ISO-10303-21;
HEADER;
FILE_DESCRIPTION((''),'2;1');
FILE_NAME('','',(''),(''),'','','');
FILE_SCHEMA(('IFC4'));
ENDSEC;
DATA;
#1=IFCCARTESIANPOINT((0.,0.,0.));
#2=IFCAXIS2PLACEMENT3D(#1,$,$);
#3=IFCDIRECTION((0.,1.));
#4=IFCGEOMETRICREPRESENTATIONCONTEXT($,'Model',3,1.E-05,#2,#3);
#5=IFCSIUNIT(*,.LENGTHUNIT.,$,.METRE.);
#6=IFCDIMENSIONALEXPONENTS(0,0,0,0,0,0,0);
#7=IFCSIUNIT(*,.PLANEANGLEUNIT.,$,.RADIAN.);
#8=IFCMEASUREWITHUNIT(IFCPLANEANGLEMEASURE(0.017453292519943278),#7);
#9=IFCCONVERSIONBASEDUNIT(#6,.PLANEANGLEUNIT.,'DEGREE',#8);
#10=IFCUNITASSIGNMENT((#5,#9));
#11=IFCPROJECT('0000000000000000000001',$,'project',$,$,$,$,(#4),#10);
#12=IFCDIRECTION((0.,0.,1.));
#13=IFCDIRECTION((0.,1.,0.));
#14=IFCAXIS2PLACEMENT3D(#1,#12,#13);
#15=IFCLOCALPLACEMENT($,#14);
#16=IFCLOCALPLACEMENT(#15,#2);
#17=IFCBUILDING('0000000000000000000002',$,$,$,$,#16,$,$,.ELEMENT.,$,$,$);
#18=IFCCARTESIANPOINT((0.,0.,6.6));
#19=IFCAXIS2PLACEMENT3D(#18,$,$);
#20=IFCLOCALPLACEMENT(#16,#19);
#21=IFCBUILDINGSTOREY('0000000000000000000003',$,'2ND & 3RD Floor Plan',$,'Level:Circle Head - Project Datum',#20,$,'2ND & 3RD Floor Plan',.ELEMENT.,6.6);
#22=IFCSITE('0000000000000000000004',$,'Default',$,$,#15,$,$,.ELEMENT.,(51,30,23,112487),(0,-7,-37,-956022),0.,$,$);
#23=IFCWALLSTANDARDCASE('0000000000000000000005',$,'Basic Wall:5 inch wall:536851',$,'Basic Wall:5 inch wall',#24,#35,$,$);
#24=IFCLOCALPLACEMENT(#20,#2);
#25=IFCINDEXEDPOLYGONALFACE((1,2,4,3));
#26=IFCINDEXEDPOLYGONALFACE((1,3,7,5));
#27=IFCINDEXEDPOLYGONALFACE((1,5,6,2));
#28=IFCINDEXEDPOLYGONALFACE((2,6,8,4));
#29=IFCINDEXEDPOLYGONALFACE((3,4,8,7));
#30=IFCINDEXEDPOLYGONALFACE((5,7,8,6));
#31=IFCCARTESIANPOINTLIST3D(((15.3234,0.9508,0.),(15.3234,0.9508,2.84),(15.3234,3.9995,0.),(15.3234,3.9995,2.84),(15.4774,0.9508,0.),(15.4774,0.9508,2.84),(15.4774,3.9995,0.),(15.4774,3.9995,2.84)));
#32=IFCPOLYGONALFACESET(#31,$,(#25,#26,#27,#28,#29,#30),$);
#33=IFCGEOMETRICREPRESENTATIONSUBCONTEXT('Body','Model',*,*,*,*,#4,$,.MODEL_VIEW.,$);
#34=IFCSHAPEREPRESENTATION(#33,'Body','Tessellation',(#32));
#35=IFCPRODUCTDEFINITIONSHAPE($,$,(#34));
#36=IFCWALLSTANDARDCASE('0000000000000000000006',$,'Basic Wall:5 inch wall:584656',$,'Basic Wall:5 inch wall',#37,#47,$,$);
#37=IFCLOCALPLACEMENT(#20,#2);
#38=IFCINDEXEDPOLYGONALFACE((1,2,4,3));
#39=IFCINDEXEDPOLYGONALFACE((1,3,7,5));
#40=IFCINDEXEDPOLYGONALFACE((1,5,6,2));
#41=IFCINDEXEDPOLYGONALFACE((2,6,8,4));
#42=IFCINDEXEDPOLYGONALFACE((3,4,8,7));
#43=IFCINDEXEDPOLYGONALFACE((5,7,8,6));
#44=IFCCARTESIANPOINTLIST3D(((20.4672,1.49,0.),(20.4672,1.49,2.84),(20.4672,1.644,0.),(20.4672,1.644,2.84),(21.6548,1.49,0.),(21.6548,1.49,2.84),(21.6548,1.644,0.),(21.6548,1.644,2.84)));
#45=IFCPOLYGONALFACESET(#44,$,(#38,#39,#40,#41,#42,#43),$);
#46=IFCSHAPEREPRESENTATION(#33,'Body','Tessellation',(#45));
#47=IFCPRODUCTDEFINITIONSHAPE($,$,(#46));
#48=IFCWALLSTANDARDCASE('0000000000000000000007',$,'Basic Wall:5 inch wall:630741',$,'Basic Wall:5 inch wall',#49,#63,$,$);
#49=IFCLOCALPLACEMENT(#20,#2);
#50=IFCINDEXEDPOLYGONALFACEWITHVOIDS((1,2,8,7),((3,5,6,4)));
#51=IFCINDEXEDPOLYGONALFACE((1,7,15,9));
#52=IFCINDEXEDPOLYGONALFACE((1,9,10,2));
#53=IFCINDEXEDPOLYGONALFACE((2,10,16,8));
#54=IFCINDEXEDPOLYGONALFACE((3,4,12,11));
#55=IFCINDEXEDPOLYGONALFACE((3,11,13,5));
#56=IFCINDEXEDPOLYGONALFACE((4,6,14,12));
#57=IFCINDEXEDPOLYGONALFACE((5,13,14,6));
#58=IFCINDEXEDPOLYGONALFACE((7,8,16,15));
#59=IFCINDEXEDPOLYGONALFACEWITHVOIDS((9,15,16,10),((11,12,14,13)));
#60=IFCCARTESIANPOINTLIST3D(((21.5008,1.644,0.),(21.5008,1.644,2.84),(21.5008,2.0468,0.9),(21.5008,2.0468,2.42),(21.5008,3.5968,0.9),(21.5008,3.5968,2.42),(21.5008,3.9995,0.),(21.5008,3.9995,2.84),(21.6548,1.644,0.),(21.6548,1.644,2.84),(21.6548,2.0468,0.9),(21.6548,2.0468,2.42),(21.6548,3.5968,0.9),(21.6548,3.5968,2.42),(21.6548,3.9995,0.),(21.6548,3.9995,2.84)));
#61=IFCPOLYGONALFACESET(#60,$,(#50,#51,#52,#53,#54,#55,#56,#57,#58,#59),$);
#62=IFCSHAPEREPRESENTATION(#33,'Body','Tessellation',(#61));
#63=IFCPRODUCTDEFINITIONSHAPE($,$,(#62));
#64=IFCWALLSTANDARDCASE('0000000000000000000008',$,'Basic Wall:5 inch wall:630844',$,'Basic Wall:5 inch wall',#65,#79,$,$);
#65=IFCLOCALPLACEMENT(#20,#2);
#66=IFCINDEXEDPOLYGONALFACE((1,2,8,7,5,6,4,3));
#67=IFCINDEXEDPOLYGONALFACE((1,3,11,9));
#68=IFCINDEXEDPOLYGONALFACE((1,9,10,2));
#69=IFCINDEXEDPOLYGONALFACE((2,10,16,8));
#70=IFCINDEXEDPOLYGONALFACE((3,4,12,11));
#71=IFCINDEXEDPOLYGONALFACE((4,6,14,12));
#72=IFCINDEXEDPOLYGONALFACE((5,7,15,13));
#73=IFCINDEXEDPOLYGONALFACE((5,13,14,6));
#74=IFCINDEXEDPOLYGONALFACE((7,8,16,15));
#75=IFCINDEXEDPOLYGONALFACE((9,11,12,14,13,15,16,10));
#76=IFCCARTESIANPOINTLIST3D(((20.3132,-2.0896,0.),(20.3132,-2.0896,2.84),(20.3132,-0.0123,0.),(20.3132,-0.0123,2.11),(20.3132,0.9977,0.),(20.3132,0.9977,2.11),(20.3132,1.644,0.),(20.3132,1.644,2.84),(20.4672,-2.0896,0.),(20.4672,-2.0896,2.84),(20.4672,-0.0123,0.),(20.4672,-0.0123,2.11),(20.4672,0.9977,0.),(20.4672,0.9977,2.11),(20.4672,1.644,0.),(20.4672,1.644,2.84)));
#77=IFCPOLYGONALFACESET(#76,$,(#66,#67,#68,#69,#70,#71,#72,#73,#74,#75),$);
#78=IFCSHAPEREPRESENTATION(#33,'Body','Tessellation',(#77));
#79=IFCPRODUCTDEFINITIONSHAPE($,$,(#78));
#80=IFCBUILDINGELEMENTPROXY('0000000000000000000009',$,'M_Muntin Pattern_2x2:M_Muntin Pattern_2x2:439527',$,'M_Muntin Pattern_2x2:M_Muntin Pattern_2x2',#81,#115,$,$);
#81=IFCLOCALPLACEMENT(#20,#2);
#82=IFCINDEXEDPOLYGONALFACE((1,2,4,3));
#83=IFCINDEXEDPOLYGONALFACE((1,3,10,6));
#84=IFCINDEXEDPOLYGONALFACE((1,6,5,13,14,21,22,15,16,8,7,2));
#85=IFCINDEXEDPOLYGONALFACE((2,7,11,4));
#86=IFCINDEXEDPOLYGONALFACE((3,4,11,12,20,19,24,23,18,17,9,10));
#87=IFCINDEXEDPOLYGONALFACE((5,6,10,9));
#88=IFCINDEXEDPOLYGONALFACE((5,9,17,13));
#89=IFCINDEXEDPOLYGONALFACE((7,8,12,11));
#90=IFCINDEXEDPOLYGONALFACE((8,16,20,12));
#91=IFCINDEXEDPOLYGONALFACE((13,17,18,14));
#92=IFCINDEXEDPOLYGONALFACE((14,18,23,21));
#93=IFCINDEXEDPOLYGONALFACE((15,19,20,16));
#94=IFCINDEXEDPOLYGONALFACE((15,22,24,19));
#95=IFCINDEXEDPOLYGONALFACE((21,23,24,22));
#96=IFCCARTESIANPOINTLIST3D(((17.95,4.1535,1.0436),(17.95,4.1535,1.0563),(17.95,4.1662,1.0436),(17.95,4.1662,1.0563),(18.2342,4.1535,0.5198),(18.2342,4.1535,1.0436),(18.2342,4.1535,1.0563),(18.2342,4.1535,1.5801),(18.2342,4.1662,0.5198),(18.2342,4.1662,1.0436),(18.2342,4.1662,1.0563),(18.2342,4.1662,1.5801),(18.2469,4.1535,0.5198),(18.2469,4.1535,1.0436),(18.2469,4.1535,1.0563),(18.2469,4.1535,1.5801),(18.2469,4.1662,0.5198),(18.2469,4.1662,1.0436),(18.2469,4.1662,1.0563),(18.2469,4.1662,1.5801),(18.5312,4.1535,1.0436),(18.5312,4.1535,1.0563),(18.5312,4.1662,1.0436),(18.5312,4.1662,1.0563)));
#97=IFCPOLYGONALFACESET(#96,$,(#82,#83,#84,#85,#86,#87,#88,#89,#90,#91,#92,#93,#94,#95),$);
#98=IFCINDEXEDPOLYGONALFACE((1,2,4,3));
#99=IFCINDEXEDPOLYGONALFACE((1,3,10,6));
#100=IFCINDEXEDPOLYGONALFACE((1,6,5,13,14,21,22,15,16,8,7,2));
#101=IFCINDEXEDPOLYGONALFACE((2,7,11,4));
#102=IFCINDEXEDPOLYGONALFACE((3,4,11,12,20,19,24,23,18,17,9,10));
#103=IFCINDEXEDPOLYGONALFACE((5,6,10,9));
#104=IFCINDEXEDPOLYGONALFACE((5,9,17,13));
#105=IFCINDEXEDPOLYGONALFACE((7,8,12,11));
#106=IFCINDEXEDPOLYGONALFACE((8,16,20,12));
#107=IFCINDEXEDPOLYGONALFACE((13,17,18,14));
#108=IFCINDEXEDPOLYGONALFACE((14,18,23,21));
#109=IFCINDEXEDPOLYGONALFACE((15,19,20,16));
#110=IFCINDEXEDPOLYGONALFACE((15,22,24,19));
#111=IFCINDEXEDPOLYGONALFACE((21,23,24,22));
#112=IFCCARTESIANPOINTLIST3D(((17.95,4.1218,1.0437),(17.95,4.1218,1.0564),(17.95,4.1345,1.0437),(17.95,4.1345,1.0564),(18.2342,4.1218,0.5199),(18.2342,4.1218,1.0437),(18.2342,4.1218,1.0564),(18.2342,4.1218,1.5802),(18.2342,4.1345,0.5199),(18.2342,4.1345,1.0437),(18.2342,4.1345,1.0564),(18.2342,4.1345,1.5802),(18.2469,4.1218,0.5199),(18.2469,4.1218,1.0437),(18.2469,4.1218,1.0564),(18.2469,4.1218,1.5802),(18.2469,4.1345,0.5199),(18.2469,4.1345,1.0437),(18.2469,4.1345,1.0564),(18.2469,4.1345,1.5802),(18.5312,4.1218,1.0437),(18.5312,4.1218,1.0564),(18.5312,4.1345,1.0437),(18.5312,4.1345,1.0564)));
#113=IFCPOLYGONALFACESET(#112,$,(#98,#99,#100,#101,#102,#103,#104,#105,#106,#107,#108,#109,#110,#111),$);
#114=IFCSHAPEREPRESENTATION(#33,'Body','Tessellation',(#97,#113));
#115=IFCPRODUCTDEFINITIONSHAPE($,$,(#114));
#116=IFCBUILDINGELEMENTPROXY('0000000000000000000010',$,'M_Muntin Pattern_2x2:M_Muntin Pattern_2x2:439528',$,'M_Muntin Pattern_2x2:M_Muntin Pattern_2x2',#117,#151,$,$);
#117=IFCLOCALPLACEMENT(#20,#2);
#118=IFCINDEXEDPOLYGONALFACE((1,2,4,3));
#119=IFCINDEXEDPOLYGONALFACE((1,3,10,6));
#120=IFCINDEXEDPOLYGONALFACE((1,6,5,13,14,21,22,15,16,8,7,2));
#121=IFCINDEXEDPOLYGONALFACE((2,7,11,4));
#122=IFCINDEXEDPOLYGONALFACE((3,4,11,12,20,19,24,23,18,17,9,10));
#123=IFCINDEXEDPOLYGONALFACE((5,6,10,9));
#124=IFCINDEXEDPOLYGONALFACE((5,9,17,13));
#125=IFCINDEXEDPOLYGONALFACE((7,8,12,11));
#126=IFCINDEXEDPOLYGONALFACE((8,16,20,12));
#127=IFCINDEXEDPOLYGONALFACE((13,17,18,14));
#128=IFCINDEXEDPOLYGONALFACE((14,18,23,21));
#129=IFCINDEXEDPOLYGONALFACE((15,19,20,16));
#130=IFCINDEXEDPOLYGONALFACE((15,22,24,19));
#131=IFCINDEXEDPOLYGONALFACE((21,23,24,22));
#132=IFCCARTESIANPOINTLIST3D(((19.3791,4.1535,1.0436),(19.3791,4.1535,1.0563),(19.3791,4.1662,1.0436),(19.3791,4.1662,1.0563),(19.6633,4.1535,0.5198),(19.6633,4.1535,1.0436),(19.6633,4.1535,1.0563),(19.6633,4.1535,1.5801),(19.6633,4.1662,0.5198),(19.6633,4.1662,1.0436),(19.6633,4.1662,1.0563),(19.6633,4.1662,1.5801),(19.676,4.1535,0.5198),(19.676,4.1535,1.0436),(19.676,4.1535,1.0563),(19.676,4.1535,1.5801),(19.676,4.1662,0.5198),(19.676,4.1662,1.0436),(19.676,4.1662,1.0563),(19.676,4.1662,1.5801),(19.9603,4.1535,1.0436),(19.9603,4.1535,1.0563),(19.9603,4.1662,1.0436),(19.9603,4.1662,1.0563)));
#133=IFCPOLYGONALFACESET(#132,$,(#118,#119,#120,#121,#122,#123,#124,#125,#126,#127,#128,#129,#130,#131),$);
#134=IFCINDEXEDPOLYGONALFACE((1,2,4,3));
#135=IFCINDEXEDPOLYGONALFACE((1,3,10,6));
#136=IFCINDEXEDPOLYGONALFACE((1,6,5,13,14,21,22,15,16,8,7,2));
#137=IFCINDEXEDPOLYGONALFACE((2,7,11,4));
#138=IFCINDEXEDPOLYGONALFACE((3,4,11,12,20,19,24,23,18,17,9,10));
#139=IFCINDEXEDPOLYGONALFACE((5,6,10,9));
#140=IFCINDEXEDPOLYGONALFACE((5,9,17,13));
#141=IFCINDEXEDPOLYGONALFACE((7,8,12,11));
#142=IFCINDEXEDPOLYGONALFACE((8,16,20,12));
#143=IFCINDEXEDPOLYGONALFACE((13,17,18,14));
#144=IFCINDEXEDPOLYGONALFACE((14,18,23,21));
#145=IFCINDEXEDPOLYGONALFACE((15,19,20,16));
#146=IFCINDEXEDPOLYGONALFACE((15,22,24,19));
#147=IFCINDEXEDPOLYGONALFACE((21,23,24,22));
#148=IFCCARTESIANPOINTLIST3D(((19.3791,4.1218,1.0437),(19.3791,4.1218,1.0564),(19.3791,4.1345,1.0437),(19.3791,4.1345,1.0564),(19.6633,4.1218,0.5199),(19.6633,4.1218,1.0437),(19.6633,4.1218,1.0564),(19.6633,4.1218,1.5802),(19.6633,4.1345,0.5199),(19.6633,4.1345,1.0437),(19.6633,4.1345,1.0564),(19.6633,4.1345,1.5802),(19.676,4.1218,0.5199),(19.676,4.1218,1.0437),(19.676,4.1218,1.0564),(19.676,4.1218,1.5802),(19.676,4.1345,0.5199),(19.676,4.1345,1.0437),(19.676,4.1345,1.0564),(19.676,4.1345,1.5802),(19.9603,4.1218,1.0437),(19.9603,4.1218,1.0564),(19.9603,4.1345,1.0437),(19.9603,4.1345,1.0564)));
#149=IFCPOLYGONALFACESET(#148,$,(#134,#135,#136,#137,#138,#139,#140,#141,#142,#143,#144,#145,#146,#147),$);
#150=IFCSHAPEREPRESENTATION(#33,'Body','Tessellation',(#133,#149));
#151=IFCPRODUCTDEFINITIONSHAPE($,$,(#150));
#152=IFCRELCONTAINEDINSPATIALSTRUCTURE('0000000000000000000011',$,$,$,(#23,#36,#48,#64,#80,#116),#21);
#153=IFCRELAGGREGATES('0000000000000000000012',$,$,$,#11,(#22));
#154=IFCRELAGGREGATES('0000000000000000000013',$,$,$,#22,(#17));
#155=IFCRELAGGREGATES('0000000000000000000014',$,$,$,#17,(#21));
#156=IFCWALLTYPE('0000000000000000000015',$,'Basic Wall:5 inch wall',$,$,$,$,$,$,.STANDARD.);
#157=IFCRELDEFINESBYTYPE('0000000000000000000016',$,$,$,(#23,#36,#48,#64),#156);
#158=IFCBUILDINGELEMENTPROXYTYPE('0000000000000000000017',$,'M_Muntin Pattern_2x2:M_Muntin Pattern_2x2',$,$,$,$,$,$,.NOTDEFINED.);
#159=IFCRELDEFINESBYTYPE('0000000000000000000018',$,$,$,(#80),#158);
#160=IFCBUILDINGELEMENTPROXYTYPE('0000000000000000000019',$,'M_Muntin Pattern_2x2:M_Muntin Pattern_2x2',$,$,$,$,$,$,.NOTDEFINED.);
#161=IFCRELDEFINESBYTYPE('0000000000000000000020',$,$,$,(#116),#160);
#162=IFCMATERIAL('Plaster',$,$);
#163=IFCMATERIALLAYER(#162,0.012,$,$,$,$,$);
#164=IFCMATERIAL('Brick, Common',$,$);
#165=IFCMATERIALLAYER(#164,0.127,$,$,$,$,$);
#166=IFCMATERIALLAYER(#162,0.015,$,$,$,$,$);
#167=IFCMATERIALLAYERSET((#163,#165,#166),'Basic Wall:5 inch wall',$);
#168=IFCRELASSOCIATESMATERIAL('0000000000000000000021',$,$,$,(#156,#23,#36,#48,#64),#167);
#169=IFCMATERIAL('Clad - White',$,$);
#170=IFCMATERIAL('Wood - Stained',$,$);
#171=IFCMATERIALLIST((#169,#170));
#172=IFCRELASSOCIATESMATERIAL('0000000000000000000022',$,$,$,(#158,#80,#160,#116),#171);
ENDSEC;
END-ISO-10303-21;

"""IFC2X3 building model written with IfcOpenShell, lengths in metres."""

from ifc_helpers import new_model, entity, si_unit, converted_unit, direction, frame, frame_2d, origin, place, context, subcontext, project, spatial, polyline, rectangle, outline, extrude, source, transform, mapped, material, material_list, layer, layer_set, layer_usage, type_object, type_shapes, element, save


model = new_model("IFC2X3")

# Units and contexts
model_context = context("Model", 3, precision=1e-05, world=origin(), true_north=direction((0.0, 1.0)))
body_context = subcontext(model_context, "Body", "Model", "MODEL_VIEW")
ifc_project = project(units=[si_unit("LENGTHUNIT", "METRE"), converted_unit("PLANEANGLEUNIT", "DEGREE", entity("IfcPlaneAngleMeasure", 0.017453292519943278), si_unit("PLANEANGLEUNIT", "RADIAN"), dimensions=[0, 0, 0, 0, 0, 0, 0])], contexts=[model_context])

# Site, building, storey
site_placement = place(None, frame((0.0, 0.0, 0.0), z_axis=(0.0, 0.0, 1.0), x_axis=(0.0, 1.0, 0.0)))
site = spatial("IfcSite", under=ifc_project, at=site_placement, Name="Default", CompositionType="ELEMENT", RefLatitude=(51, 30, 23, 112487), RefLongitude=(0, -7, -37, -956022), RefElevation=0.0)
building_placement = place(site_placement, origin())
building = spatial("IfcBuilding", under=site, at=building_placement, CompositionType="ELEMENT")
storey_placement = place(building_placement, frame((0.0, 0.0, 6.6)))
storey = spatial("IfcBuildingStorey", under=building, at=storey_placement, Name="2ND & 3RD Floor Plan", ObjectType="Level:Circle Head - Project Datum", LongName="2ND & 3RD Floor Plan", CompositionType="ELEMENT", Elevation=6.6)

# Walls
ifc_material_1 = material(Name="Plaster")
ifc_layer_1 = layer(ifc_material_1, 0.012)
ifc_material_2 = material(Name="Brick, Common")
ifc_layer_2 = layer(ifc_material_2, 0.127)
ifc_layer_3 = layer(ifc_material_1, 0.015)
ifc_layer_set = layer_set([ifc_layer_1, ifc_layer_2, ifc_layer_3], Name="Basic Wall:5 inch wall")
ifc_layer_usage_1 = layer_usage(ifc_layer_set, "AXIS2", "NEGATIVE", 0.077)
wall_type = type_object("IfcWallType", Name="Basic Wall:5 inch wall", PredefinedType="STANDARD", material=ifc_layer_set)
wall_1_placement = place(storey_placement, frame((15.4004, 3.9995, 0.0), z_axis=(0.0, 0.0, 1.0), x_axis=(0.0, -1.0, 0.0)))
element("IfcWallStandardCase", 1, at=wall_1_placement, inside=storey, type_object=wall_type, material=ifc_layer_usage_1, Name="Basic Wall:5 inch wall:536851", ObjectType="Basic Wall:5 inch wall", context=body_context, shape_type="SweptSolid", body=[
    extrude(rectangle(XDim=3.0487, YDim=0.154, at=frame_2d((1.5244, 0.0), x_axis=(-1.0, 0.0))), origin(), (0.0, 0.0, 1.0), 2.84),
])
ifc_layer_usage_2 = layer_usage(ifc_layer_set, "AXIS2", "NEGATIVE", 0.077)
wall_2_placement = place(storey_placement, frame((21.6548, 1.567, 0.0), z_axis=(0.0, 0.0, 1.0), x_axis=(-1.0, 0.0, 0.0)))
element("IfcWallStandardCase", 2, at=wall_2_placement, inside=storey, type_object=wall_type, material=ifc_layer_usage_2, Name="Basic Wall:5 inch wall:584656", ObjectType="Basic Wall:5 inch wall", context=body_context, shape_type="SweptSolid", body=[
    extrude(rectangle(XDim=1.1876, YDim=0.154, at=frame_2d((0.5938, 0.0), x_axis=(-1.0, 0.0))), origin(), (0.0, 0.0, 1.0), 2.84),
])

# Walls, openings
ifc_layer_usage_3 = layer_usage(ifc_layer_set, "AXIS2", "POSITIVE", -0.077)
wall_3_placement = place(storey_placement, frame((21.5778, 3.9995, 0.0), z_axis=(0.0, 0.0, 1.0), x_axis=(0.0, -1.0, 0.0)))
wall_3 = element("IfcWallStandardCase", 3, at=wall_3_placement, inside=storey, type_object=wall_type, material=ifc_layer_usage_3, Name="Basic Wall:5 inch wall:630741", ObjectType="Basic Wall:5 inch wall", context=body_context, shape_type="SweptSolid", body=[
    extrude(rectangle(XDim=2.3556, YDim=0.154, at=frame_2d((1.1778, 0.0), x_axis=(-1.0, 0.0))), origin(), (0.0, 0.0, 1.0), 2.84),
])
opening_1_placement = place(wall_3_placement, frame((0.4028, -0.077, 0.9)))
element("IfcOpeningElement", 4, at=opening_1_placement, cuts=wall_3, ObjectType="Opening", context=body_context, shape_type="SweptSolid", body=[
    extrude(rectangle(XDim=1.52, YDim=1.55, at=frame_2d((0.76, 0.775), x_axis=(-1.0, 0.0))), frame((0.0, 0.0, 0.0), z_axis=(0.0, 1.0, 0.0), x_axis=(0.0, 0.0, 1.0)), (0.0, 0.0, 1.0), 0.154),
])
ifc_layer_usage_4 = layer_usage(ifc_layer_set, "AXIS2", "NEGATIVE", 0.077)
wall_4_placement = place(storey_placement, frame((20.3902, 1.644, 0.0), z_axis=(0.0, 0.0, 1.0), x_axis=(0.0, -1.0, 0.0)))
wall_4 = element("IfcWallStandardCase", 5, at=wall_4_placement, inside=storey, type_object=wall_type, material=ifc_layer_usage_4, Name="Basic Wall:5 inch wall:630844", ObjectType="Basic Wall:5 inch wall", context=body_context, shape_type="SweptSolid", body=[
    extrude(rectangle(XDim=3.7336, YDim=0.154, at=frame_2d((1.8668, 0.0), x_axis=(1.0, 0.0))), origin(), (0.0, 0.0, 1.0), 2.84),
])
opening_2_placement = place(wall_4_placement, frame((1.6562, 0.077, 0.0)))
element("IfcOpeningElement", 6, at=opening_2_placement, cuts=wall_4, ObjectType="Opening", context=body_context, shape_type="SweptSolid", body=[
    extrude(rectangle(XDim=2.11, YDim=1.01, at=frame_2d((1.055, 0.505), x_axis=(1.0, 0.0))), frame((0.0, 0.0, 0.0), z_axis=(0.0, -1.0, 0.0), x_axis=(0.0, 0.0, 1.0)), (0.0, 0.0, 1.0), 0.154),
])

# Building element proxies
ifc_material_3 = material(Name="Clad - White")
ifc_material_4 = material(Name="Wood - Stained")
ifc_material_list = material_list([ifc_material_3, ifc_material_4])
building_element_proxy_type_1 = type_object("IfcBuildingElementProxyType", Name="M_Muntin Pattern_2x2:M_Muntin Pattern_2x2", PredefinedType="NOTDEFINED", material=ifc_material_list)
shared_shape_1 = source(origin(), body_context, "Body", "SweptSolid", [
    extrude(outline(polyline([(0.0064, -0.0064), (0.5301, -0.0064), (0.5301, 0.0063), (0.0064, 0.0063), (0.0064, 0.2906), (-0.0063, 0.2906), (-0.0063, 0.0063), (-0.5302, 0.0063), (-0.5302, -0.0064), (-0.0063, -0.0064), (-0.0063, -0.2906), (0.0064, -0.2906), (0.0064, -0.0064)])), frame((0.0, 0.0095, 0.5301), z_axis=(0.0, 1.0, 0.0), x_axis=(0.0, 0.0, 1.0)), (0.0, 0.0, 1.0), 0.0127),
    extrude(outline(polyline([(0.0064, -0.0064), (0.5302, -0.0064), (0.5302, 0.0063), (0.0064, 0.0063), (0.0064, 0.2906), (-0.0063, 0.2906), (-0.0063, 0.0063), (-0.5302, 0.0063), (-0.5302, -0.0064), (-0.0063, -0.0064), (-0.0063, -0.2906), (0.0064, -0.2906), (0.0064, -0.0064)])), frame((0.0, -0.0222, 0.5302), z_axis=(0.0, 1.0, 0.0), x_axis=(0.0, 0.0, 1.0)), (0.0, 0.0, 1.0), 0.0127),
])
type_shapes(building_element_proxy_type_1, [shared_shape_1])
proxy_1_placement = place(storey_placement, frame((18.2406, 4.144, 0.5199)))
element("IfcBuildingElementProxy", 7, at=proxy_1_placement, inside=storey, type_object=building_element_proxy_type_1, material=ifc_material_list, Name="M_Muntin Pattern_2x2:M_Muntin Pattern_2x2:439527", ObjectType="M_Muntin Pattern_2x2:M_Muntin Pattern_2x2", context=body_context, shape_type="MappedRepresentation", body=[
    mapped(shared_shape_1, transform((0.0, 0.0, 0.0), scale=1.0)),
])
building_element_proxy_type_2 = type_object("IfcBuildingElementProxyType", Name="M_Muntin Pattern_2x2:M_Muntin Pattern_2x2", PredefinedType="NOTDEFINED", material=ifc_material_list)
shared_shape_2 = source(origin(), body_context, "Body", "SweptSolid", [
    extrude(outline(polyline([(0.0064, -0.0064), (0.5301, -0.0064), (0.5301, 0.0063), (0.0064, 0.0063), (0.0064, 0.2906), (-0.0063, 0.2906), (-0.0063, 0.0063), (-0.5302, 0.0063), (-0.5302, -0.0064), (-0.0063, -0.0064), (-0.0063, -0.2906), (0.0064, -0.2906), (0.0064, -0.0064)])), frame((0.0, -0.0222, 0.5301), z_axis=(0.0, 1.0, 0.0), x_axis=(0.0, 0.0, 1.0)), (0.0, 0.0, 1.0), 0.0127),
    extrude(outline(polyline([(0.0064, -0.0064), (0.5302, -0.0064), (0.5302, 0.0063), (0.0064, 0.0063), (0.0064, 0.2906), (-0.0063, 0.2906), (-0.0063, 0.0063), (-0.5302, 0.0063), (-0.5302, -0.0064), (-0.0063, -0.0064), (-0.0063, -0.2906), (0.0064, -0.2906), (0.0064, -0.0064)])), frame((0.0, 0.0095, 0.5302), z_axis=(0.0, 1.0, 0.0), x_axis=(0.0, 0.0, 1.0)), (0.0, 0.0, 1.0), 0.0127),
])
type_shapes(building_element_proxy_type_2, [shared_shape_2])
for number, where, z_axis, x_axis, name in (
    (8, (19.6697, 4.144, 0.5199), (0.0, 0.0, 1.0), (-1.0, 0.0, 0.0), "M_Muntin Pattern_2x2:M_Muntin Pattern_2x2:439528"),
):
    element("IfcBuildingElementProxy", number, at=place(storey_placement, frame(where, z_axis=z_axis, x_axis=x_axis)), inside=storey, type_object=building_element_proxy_type_2, material=ifc_material_list, Name=name, ObjectType="M_Muntin Pattern_2x2:M_Muntin Pattern_2x2", context=body_context, shape_type="MappedRepresentation", body=[
        mapped(shared_shape_2, transform((0.0, 0.0, 0.0), scale=1.0)),
    ])

save(model, "model.ifc")
